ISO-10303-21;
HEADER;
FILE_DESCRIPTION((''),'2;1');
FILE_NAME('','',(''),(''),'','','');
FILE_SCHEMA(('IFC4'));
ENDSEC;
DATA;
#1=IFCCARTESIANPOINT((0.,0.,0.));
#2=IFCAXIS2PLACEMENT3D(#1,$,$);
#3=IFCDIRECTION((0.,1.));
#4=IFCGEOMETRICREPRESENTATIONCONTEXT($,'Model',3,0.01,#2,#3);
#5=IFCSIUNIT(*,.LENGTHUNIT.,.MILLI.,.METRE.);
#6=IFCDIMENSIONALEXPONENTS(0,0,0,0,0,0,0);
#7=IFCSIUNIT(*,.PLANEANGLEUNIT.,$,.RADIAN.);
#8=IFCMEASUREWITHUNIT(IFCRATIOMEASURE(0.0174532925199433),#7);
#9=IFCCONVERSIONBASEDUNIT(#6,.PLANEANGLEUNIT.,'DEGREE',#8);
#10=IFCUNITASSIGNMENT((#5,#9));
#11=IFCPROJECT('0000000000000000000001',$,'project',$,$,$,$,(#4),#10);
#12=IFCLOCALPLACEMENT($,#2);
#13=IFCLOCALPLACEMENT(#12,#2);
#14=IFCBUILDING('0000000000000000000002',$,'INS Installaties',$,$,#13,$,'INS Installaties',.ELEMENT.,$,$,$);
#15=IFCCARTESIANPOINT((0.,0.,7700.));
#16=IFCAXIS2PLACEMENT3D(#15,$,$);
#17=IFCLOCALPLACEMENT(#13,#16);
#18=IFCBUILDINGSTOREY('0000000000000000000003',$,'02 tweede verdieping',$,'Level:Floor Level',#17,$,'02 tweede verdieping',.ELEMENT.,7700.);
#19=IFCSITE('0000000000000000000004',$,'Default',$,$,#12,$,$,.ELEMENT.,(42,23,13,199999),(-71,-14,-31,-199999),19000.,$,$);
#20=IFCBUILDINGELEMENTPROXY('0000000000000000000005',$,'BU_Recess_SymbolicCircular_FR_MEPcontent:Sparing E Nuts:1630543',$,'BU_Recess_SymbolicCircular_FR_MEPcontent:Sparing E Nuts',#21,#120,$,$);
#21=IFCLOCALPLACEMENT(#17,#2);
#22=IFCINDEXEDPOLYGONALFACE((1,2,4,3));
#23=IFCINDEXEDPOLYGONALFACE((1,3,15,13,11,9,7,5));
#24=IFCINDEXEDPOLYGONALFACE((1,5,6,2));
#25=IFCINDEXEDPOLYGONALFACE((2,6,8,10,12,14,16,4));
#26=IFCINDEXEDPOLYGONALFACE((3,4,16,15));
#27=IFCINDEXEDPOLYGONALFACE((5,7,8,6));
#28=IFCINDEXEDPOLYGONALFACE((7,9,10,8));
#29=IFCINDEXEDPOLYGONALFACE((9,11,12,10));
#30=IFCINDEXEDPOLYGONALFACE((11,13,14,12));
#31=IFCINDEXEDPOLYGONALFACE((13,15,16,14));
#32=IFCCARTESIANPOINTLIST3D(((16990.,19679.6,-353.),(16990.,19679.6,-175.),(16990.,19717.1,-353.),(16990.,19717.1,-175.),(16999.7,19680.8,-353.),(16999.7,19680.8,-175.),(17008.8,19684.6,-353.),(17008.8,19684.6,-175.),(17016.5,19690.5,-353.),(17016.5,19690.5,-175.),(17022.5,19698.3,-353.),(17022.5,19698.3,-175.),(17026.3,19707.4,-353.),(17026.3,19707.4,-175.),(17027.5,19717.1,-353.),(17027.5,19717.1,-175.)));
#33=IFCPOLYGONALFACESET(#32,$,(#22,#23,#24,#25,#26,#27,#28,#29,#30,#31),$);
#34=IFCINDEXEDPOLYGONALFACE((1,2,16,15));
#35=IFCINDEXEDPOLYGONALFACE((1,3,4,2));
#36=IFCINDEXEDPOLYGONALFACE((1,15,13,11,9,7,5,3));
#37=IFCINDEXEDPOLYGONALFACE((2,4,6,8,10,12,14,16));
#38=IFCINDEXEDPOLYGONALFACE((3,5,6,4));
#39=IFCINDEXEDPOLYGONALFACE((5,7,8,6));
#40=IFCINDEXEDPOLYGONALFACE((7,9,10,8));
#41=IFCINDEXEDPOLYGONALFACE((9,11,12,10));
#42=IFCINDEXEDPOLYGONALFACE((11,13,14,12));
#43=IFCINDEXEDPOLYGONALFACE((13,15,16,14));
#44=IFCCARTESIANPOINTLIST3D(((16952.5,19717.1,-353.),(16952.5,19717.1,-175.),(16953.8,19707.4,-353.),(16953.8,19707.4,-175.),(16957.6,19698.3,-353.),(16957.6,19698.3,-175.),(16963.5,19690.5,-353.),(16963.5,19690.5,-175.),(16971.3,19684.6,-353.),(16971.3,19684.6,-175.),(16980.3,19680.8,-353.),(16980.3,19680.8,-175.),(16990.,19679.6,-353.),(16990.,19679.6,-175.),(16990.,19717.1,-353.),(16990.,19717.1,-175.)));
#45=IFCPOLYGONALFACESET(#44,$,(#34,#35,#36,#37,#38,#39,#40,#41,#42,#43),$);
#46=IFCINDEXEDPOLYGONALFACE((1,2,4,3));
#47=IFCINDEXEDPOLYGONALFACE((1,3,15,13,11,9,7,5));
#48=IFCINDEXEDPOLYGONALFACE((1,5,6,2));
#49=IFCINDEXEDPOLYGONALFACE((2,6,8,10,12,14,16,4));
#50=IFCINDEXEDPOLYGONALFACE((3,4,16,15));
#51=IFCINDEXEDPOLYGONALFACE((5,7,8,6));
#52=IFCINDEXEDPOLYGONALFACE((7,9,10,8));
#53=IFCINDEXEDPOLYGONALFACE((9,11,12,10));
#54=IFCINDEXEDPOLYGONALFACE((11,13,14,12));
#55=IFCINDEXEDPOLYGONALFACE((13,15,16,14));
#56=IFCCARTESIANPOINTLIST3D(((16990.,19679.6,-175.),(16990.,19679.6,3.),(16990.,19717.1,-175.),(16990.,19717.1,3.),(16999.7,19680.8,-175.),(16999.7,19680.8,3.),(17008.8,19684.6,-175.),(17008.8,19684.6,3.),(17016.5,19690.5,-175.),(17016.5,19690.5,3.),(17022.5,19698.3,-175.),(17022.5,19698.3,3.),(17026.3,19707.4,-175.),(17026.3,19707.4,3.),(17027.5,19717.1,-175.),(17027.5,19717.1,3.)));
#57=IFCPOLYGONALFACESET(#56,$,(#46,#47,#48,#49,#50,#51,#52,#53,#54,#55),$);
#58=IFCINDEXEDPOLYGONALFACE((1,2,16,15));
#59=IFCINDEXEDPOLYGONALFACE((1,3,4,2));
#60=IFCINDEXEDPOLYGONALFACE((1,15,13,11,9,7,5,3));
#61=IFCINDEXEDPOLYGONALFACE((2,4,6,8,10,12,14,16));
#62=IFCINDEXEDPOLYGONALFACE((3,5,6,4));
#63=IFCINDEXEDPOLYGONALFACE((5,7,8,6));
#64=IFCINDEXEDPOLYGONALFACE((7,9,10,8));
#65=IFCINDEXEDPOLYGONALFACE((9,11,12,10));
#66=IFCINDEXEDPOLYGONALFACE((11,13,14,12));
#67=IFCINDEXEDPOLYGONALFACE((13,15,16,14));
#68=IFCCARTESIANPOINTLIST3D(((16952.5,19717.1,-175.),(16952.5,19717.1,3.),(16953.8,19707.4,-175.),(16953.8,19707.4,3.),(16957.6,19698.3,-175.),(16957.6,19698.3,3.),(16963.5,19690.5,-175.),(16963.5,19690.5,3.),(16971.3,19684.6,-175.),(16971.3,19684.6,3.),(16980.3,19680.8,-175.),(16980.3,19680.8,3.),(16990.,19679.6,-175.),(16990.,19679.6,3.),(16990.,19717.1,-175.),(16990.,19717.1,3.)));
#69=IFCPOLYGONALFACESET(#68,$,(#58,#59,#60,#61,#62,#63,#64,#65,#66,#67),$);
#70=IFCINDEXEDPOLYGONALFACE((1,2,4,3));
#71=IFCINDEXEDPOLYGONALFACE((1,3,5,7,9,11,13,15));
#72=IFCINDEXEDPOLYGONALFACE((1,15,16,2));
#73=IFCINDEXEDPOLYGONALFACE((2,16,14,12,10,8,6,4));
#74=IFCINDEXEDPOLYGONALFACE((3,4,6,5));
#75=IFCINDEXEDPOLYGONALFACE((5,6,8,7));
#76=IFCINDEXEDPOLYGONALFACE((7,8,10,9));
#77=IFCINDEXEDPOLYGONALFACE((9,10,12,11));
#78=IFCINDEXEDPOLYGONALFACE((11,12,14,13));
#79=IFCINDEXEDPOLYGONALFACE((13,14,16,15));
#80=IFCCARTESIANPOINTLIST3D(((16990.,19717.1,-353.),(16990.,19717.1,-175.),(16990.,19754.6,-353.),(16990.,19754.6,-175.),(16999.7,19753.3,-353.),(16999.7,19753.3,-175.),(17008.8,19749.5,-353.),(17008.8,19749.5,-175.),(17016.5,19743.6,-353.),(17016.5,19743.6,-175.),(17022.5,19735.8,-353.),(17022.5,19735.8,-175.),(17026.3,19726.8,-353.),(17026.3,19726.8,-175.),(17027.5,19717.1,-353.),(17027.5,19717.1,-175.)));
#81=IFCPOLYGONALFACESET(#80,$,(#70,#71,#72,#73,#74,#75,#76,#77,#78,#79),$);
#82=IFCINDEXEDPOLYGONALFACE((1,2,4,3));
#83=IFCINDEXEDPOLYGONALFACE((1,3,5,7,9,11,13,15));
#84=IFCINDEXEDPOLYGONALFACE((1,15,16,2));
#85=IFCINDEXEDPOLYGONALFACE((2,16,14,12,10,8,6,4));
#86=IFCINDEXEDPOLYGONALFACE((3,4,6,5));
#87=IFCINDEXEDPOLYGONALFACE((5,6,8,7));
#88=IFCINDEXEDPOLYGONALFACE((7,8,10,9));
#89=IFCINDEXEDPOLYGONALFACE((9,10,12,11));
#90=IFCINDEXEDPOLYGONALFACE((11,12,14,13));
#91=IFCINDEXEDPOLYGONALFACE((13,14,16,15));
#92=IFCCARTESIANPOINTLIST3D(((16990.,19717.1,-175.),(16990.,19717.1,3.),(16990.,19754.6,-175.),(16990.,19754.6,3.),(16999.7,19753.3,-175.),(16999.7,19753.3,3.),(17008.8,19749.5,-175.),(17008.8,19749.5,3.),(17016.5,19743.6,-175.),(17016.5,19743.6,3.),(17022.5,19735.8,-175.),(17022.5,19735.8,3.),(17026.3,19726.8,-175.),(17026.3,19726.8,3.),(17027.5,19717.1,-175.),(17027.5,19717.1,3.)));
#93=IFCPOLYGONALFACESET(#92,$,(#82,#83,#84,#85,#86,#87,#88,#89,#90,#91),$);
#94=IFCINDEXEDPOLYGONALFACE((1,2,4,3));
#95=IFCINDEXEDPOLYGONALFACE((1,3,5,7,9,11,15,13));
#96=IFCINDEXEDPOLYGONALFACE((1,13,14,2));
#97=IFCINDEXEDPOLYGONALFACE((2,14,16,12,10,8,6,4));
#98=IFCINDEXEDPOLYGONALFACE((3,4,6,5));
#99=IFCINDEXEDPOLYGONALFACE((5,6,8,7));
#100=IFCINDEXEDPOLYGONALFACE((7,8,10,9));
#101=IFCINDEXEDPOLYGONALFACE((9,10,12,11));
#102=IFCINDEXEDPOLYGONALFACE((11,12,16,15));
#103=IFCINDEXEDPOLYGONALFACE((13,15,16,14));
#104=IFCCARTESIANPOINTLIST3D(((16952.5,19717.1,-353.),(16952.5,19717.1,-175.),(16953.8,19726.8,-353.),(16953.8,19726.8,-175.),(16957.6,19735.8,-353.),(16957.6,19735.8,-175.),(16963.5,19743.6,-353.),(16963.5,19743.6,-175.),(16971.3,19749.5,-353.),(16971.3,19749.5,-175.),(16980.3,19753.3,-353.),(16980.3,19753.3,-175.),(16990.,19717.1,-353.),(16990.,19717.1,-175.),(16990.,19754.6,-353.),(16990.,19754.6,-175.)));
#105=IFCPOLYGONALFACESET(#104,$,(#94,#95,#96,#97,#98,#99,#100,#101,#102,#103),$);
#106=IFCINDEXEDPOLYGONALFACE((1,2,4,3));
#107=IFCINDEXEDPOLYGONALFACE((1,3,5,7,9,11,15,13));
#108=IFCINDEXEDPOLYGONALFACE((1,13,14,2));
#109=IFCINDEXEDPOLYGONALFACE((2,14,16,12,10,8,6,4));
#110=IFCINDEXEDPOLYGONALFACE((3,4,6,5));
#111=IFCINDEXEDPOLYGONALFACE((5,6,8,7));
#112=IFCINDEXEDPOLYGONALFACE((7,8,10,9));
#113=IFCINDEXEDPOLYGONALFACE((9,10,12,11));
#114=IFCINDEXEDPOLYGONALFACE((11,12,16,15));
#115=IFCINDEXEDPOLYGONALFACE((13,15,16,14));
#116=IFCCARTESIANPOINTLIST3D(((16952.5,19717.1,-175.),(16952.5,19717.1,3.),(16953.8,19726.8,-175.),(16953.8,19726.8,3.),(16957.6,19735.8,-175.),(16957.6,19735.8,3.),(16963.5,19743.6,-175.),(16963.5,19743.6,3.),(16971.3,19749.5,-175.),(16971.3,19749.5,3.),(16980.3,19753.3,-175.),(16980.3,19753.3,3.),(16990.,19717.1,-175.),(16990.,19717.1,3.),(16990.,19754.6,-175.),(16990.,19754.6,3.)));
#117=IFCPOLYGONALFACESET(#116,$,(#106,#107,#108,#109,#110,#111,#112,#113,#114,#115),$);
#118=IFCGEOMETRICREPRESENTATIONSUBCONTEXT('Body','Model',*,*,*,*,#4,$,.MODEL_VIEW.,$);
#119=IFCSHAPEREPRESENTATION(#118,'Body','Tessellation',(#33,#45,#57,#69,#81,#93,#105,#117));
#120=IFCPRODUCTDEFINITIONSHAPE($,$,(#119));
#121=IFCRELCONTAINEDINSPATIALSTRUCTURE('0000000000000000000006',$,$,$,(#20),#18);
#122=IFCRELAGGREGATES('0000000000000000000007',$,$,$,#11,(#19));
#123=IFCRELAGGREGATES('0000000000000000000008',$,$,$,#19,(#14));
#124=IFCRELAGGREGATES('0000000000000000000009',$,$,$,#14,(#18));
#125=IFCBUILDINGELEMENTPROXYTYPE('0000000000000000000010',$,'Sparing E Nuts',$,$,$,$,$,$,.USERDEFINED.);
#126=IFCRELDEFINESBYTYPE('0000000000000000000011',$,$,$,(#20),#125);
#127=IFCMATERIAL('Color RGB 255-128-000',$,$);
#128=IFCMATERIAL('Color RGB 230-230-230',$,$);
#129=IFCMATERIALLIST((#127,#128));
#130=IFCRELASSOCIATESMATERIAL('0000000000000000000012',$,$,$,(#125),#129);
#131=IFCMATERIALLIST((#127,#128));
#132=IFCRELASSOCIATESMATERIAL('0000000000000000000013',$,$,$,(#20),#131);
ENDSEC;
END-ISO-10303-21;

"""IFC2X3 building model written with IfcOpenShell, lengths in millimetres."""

from ifc_helpers import new_model, entity, si_unit, converted_unit, direction, frame, frame_2d, origin, place, context, subcontext, project, spatial, polyline, circle_curve, parameter, trimmed, segment, composite_curve, outline, extrude, source, transform, mapped, material, material_list, type_object, type_shapes, element, save


model = new_model("IFC2X3")

# Units and contexts
model_context = context("Model", 3, precision=0.01, world=origin(), true_north=direction((0.0, 1.0)))
body_context = subcontext(model_context, "Body", "Model", "MODEL_VIEW")
ifc_project = project(units=[si_unit("LENGTHUNIT", "METRE", prefix="MILLI"), converted_unit("PLANEANGLEUNIT", "DEGREE", entity("IfcRatioMeasure", 0.0174532925199433), si_unit("PLANEANGLEUNIT", "RADIAN"), dimensions=[0, 0, 0, 0, 0, 0, 0])], contexts=[model_context])

# Site, building, storey
site_placement = place(None, origin())
site = spatial("IfcSite", under=ifc_project, at=site_placement, Name="Default", CompositionType="ELEMENT", RefLatitude=(42, 23, 13, 199999), RefLongitude=(-71, -14, -31, -199999), RefElevation=19000.0)
building_placement = place(site_placement, origin())
building = spatial("IfcBuilding", under=site, at=building_placement, Name="INS Installaties", LongName="INS Installaties", CompositionType="ELEMENT")
storey_placement = place(building_placement, frame((0.0, 0.0, 7700.0)))
storey = spatial("IfcBuildingStorey", under=building, at=storey_placement, Name="02 tweede verdieping", ObjectType="Level:Floor Level", LongName="02 tweede verdieping", CompositionType="ELEMENT", Elevation=7700.0)

# Building element proxy
ifc_material_1 = material(Name="Color RGB 255-128-000")
ifc_material_2 = material(Name="Color RGB 230-230-230")
ifc_material_list_1 = material_list([ifc_material_1, ifc_material_2])
ifc_material_list_2 = material_list([ifc_material_1, ifc_material_2])
building_element_proxy_type_1 = type_object("IfcBuildingElementProxyType", Name="Sparing E Nuts", PredefinedType="USERDEFINED", material=ifc_material_list_2)
shared_shape_1 = source(origin(), body_context, "Body", "SweptSolid", [
    extrude(outline(composite_curve([segment(polyline([(-25.0, -12.5), (12.5, -12.5)]), True, "CONTINUOUS"), segment(polyline([(12.5, -12.5), (12.5, 25.0)]), True, "CONTINUOUS"), segment(trimmed(circle_curve(frame_2d((12.5, -12.5), x_axis=(1.0, 0.0)), 37.5), [parameter(90.0)], [parameter(180.0)], True, "PARAMETER"), True, "CONTINUOUS")], self_intersect=False)), frame((12.5, -12.5, -353.0), z_axis=(0.0, 0.0, 1.0), x_axis=(-1.0, 0.0, 0.0)), (0.0, 0.0, 1.0), 178.0),
    extrude(outline(composite_curve([segment(trimmed(circle_curve(frame_2d((12.5, 12.5), x_axis=(1.0, 0.0)), 37.5), [parameter(180.0)], [parameter(270.0)], True, "PARAMETER"), True, "CONTINUOUS"), segment(polyline([(12.5, -25.0), (12.5, 12.5)]), True, "CONTINUOUS"), segment(polyline([(12.5, 12.5), (-25.0, 12.5)]), True, "CONTINUOUS")], self_intersect=False)), frame((-12.5, -12.5, -353.0)), (0.0, 0.0, 1.0), 178.0),
    extrude(outline(composite_curve([segment(polyline([(-25.0, -12.5), (12.5, -12.5)]), True, "CONTINUOUS"), segment(polyline([(12.5, -12.5), (12.5, 25.0)]), True, "CONTINUOUS"), segment(trimmed(circle_curve(frame_2d((12.5, -12.5), x_axis=(1.0, 0.0)), 37.5), [parameter(90.0)], [parameter(180.0)], True, "PARAMETER"), True, "CONTINUOUS")], self_intersect=False)), frame((12.5, -12.5, -175.0), z_axis=(0.0, 0.0, 1.0), x_axis=(-1.0, 0.0, 0.0)), (0.0, 0.0, 1.0), 178.0),
    extrude(outline(composite_curve([segment(trimmed(circle_curve(frame_2d((12.5, 12.5), x_axis=(1.0, 0.0)), 37.5), [parameter(180.0)], [parameter(270.0)], True, "PARAMETER"), True, "CONTINUOUS"), segment(polyline([(12.5, -25.0), (12.5, 12.5)]), True, "CONTINUOUS"), segment(polyline([(12.5, 12.5), (-25.0, 12.5)]), True, "CONTINUOUS")], self_intersect=False)), frame((-12.5, -12.5, -175.0)), (0.0, 0.0, 1.0), 178.0),
    extrude(outline(composite_curve([segment(trimmed(circle_curve(frame_2d((12.5, 12.5), x_axis=(1.0, 0.0)), 37.5), [parameter(180.0)], [parameter(270.0)], True, "PARAMETER"), True, "CONTINUOUS"), segment(polyline([(12.5, -25.0), (12.5, 12.5)]), True, "CONTINUOUS"), segment(polyline([(12.5, 12.5), (-25.0, 12.5)]), True, "CONTINUOUS")], self_intersect=False)), frame((12.5, 12.5, -353.0), z_axis=(0.0, 0.0, 1.0), x_axis=(-1.0, 0.0, 0.0)), (0.0, 0.0, 1.0), 178.0),
    extrude(outline(composite_curve([segment(trimmed(circle_curve(frame_2d((12.5, 12.5), x_axis=(1.0, 0.0)), 37.5), [parameter(180.0)], [parameter(270.0)], True, "PARAMETER"), True, "CONTINUOUS"), segment(polyline([(12.5, -25.0), (12.5, 12.5)]), True, "CONTINUOUS"), segment(polyline([(12.5, 12.5), (-25.0, 12.5)]), True, "CONTINUOUS")], self_intersect=False)), frame((12.5, 12.5, -175.0), z_axis=(0.0, 0.0, 1.0), x_axis=(-1.0, 0.0, 0.0)), (0.0, 0.0, 1.0), 178.0),
    extrude(outline(composite_curve([segment(polyline([(-25.0, -12.5), (12.5, -12.5)]), True, "CONTINUOUS"), segment(polyline([(12.5, -12.5), (12.5, 25.0)]), True, "CONTINUOUS"), segment(trimmed(circle_curve(frame_2d((12.5, -12.5), x_axis=(1.0, 0.0)), 37.5), [parameter(90.0)], [parameter(180.0)], True, "PARAMETER"), True, "CONTINUOUS")], self_intersect=False)), frame((-12.5, 12.5, -353.0)), (0.0, 0.0, 1.0), 178.0),
    extrude(outline(composite_curve([segment(polyline([(-25.0, -12.5), (12.5, -12.5)]), True, "CONTINUOUS"), segment(polyline([(12.5, -12.5), (12.5, 25.0)]), True, "CONTINUOUS"), segment(trimmed(circle_curve(frame_2d((12.5, -12.5), x_axis=(1.0, 0.0)), 37.5), [parameter(90.0)], [parameter(180.0)], True, "PARAMETER"), True, "CONTINUOUS")], self_intersect=False)), frame((-12.5, 12.5, -175.0)), (0.0, 0.0, 1.0), 178.0),
])
type_shapes(building_element_proxy_type_1, [shared_shape_1])
proxy_1_placement = place(storey_placement, frame((16990.0, 19717.1, 0.0)))
element("IfcBuildingElementProxy", 1, at=proxy_1_placement, inside=storey, type_object=building_element_proxy_type_1, material=ifc_material_list_1, Name="BU_Recess_SymbolicCircular_FR_MEPcontent:Sparing E Nuts:1630543", ObjectType="BU_Recess_SymbolicCircular_FR_MEPcontent:Sparing E Nuts", context=body_context, shape_type="MappedRepresentation", body=[
    mapped(shared_shape_1, transform((0.0, 0.0, 0.0), scale=1.0)),
])

save(model, "model.ifc")
